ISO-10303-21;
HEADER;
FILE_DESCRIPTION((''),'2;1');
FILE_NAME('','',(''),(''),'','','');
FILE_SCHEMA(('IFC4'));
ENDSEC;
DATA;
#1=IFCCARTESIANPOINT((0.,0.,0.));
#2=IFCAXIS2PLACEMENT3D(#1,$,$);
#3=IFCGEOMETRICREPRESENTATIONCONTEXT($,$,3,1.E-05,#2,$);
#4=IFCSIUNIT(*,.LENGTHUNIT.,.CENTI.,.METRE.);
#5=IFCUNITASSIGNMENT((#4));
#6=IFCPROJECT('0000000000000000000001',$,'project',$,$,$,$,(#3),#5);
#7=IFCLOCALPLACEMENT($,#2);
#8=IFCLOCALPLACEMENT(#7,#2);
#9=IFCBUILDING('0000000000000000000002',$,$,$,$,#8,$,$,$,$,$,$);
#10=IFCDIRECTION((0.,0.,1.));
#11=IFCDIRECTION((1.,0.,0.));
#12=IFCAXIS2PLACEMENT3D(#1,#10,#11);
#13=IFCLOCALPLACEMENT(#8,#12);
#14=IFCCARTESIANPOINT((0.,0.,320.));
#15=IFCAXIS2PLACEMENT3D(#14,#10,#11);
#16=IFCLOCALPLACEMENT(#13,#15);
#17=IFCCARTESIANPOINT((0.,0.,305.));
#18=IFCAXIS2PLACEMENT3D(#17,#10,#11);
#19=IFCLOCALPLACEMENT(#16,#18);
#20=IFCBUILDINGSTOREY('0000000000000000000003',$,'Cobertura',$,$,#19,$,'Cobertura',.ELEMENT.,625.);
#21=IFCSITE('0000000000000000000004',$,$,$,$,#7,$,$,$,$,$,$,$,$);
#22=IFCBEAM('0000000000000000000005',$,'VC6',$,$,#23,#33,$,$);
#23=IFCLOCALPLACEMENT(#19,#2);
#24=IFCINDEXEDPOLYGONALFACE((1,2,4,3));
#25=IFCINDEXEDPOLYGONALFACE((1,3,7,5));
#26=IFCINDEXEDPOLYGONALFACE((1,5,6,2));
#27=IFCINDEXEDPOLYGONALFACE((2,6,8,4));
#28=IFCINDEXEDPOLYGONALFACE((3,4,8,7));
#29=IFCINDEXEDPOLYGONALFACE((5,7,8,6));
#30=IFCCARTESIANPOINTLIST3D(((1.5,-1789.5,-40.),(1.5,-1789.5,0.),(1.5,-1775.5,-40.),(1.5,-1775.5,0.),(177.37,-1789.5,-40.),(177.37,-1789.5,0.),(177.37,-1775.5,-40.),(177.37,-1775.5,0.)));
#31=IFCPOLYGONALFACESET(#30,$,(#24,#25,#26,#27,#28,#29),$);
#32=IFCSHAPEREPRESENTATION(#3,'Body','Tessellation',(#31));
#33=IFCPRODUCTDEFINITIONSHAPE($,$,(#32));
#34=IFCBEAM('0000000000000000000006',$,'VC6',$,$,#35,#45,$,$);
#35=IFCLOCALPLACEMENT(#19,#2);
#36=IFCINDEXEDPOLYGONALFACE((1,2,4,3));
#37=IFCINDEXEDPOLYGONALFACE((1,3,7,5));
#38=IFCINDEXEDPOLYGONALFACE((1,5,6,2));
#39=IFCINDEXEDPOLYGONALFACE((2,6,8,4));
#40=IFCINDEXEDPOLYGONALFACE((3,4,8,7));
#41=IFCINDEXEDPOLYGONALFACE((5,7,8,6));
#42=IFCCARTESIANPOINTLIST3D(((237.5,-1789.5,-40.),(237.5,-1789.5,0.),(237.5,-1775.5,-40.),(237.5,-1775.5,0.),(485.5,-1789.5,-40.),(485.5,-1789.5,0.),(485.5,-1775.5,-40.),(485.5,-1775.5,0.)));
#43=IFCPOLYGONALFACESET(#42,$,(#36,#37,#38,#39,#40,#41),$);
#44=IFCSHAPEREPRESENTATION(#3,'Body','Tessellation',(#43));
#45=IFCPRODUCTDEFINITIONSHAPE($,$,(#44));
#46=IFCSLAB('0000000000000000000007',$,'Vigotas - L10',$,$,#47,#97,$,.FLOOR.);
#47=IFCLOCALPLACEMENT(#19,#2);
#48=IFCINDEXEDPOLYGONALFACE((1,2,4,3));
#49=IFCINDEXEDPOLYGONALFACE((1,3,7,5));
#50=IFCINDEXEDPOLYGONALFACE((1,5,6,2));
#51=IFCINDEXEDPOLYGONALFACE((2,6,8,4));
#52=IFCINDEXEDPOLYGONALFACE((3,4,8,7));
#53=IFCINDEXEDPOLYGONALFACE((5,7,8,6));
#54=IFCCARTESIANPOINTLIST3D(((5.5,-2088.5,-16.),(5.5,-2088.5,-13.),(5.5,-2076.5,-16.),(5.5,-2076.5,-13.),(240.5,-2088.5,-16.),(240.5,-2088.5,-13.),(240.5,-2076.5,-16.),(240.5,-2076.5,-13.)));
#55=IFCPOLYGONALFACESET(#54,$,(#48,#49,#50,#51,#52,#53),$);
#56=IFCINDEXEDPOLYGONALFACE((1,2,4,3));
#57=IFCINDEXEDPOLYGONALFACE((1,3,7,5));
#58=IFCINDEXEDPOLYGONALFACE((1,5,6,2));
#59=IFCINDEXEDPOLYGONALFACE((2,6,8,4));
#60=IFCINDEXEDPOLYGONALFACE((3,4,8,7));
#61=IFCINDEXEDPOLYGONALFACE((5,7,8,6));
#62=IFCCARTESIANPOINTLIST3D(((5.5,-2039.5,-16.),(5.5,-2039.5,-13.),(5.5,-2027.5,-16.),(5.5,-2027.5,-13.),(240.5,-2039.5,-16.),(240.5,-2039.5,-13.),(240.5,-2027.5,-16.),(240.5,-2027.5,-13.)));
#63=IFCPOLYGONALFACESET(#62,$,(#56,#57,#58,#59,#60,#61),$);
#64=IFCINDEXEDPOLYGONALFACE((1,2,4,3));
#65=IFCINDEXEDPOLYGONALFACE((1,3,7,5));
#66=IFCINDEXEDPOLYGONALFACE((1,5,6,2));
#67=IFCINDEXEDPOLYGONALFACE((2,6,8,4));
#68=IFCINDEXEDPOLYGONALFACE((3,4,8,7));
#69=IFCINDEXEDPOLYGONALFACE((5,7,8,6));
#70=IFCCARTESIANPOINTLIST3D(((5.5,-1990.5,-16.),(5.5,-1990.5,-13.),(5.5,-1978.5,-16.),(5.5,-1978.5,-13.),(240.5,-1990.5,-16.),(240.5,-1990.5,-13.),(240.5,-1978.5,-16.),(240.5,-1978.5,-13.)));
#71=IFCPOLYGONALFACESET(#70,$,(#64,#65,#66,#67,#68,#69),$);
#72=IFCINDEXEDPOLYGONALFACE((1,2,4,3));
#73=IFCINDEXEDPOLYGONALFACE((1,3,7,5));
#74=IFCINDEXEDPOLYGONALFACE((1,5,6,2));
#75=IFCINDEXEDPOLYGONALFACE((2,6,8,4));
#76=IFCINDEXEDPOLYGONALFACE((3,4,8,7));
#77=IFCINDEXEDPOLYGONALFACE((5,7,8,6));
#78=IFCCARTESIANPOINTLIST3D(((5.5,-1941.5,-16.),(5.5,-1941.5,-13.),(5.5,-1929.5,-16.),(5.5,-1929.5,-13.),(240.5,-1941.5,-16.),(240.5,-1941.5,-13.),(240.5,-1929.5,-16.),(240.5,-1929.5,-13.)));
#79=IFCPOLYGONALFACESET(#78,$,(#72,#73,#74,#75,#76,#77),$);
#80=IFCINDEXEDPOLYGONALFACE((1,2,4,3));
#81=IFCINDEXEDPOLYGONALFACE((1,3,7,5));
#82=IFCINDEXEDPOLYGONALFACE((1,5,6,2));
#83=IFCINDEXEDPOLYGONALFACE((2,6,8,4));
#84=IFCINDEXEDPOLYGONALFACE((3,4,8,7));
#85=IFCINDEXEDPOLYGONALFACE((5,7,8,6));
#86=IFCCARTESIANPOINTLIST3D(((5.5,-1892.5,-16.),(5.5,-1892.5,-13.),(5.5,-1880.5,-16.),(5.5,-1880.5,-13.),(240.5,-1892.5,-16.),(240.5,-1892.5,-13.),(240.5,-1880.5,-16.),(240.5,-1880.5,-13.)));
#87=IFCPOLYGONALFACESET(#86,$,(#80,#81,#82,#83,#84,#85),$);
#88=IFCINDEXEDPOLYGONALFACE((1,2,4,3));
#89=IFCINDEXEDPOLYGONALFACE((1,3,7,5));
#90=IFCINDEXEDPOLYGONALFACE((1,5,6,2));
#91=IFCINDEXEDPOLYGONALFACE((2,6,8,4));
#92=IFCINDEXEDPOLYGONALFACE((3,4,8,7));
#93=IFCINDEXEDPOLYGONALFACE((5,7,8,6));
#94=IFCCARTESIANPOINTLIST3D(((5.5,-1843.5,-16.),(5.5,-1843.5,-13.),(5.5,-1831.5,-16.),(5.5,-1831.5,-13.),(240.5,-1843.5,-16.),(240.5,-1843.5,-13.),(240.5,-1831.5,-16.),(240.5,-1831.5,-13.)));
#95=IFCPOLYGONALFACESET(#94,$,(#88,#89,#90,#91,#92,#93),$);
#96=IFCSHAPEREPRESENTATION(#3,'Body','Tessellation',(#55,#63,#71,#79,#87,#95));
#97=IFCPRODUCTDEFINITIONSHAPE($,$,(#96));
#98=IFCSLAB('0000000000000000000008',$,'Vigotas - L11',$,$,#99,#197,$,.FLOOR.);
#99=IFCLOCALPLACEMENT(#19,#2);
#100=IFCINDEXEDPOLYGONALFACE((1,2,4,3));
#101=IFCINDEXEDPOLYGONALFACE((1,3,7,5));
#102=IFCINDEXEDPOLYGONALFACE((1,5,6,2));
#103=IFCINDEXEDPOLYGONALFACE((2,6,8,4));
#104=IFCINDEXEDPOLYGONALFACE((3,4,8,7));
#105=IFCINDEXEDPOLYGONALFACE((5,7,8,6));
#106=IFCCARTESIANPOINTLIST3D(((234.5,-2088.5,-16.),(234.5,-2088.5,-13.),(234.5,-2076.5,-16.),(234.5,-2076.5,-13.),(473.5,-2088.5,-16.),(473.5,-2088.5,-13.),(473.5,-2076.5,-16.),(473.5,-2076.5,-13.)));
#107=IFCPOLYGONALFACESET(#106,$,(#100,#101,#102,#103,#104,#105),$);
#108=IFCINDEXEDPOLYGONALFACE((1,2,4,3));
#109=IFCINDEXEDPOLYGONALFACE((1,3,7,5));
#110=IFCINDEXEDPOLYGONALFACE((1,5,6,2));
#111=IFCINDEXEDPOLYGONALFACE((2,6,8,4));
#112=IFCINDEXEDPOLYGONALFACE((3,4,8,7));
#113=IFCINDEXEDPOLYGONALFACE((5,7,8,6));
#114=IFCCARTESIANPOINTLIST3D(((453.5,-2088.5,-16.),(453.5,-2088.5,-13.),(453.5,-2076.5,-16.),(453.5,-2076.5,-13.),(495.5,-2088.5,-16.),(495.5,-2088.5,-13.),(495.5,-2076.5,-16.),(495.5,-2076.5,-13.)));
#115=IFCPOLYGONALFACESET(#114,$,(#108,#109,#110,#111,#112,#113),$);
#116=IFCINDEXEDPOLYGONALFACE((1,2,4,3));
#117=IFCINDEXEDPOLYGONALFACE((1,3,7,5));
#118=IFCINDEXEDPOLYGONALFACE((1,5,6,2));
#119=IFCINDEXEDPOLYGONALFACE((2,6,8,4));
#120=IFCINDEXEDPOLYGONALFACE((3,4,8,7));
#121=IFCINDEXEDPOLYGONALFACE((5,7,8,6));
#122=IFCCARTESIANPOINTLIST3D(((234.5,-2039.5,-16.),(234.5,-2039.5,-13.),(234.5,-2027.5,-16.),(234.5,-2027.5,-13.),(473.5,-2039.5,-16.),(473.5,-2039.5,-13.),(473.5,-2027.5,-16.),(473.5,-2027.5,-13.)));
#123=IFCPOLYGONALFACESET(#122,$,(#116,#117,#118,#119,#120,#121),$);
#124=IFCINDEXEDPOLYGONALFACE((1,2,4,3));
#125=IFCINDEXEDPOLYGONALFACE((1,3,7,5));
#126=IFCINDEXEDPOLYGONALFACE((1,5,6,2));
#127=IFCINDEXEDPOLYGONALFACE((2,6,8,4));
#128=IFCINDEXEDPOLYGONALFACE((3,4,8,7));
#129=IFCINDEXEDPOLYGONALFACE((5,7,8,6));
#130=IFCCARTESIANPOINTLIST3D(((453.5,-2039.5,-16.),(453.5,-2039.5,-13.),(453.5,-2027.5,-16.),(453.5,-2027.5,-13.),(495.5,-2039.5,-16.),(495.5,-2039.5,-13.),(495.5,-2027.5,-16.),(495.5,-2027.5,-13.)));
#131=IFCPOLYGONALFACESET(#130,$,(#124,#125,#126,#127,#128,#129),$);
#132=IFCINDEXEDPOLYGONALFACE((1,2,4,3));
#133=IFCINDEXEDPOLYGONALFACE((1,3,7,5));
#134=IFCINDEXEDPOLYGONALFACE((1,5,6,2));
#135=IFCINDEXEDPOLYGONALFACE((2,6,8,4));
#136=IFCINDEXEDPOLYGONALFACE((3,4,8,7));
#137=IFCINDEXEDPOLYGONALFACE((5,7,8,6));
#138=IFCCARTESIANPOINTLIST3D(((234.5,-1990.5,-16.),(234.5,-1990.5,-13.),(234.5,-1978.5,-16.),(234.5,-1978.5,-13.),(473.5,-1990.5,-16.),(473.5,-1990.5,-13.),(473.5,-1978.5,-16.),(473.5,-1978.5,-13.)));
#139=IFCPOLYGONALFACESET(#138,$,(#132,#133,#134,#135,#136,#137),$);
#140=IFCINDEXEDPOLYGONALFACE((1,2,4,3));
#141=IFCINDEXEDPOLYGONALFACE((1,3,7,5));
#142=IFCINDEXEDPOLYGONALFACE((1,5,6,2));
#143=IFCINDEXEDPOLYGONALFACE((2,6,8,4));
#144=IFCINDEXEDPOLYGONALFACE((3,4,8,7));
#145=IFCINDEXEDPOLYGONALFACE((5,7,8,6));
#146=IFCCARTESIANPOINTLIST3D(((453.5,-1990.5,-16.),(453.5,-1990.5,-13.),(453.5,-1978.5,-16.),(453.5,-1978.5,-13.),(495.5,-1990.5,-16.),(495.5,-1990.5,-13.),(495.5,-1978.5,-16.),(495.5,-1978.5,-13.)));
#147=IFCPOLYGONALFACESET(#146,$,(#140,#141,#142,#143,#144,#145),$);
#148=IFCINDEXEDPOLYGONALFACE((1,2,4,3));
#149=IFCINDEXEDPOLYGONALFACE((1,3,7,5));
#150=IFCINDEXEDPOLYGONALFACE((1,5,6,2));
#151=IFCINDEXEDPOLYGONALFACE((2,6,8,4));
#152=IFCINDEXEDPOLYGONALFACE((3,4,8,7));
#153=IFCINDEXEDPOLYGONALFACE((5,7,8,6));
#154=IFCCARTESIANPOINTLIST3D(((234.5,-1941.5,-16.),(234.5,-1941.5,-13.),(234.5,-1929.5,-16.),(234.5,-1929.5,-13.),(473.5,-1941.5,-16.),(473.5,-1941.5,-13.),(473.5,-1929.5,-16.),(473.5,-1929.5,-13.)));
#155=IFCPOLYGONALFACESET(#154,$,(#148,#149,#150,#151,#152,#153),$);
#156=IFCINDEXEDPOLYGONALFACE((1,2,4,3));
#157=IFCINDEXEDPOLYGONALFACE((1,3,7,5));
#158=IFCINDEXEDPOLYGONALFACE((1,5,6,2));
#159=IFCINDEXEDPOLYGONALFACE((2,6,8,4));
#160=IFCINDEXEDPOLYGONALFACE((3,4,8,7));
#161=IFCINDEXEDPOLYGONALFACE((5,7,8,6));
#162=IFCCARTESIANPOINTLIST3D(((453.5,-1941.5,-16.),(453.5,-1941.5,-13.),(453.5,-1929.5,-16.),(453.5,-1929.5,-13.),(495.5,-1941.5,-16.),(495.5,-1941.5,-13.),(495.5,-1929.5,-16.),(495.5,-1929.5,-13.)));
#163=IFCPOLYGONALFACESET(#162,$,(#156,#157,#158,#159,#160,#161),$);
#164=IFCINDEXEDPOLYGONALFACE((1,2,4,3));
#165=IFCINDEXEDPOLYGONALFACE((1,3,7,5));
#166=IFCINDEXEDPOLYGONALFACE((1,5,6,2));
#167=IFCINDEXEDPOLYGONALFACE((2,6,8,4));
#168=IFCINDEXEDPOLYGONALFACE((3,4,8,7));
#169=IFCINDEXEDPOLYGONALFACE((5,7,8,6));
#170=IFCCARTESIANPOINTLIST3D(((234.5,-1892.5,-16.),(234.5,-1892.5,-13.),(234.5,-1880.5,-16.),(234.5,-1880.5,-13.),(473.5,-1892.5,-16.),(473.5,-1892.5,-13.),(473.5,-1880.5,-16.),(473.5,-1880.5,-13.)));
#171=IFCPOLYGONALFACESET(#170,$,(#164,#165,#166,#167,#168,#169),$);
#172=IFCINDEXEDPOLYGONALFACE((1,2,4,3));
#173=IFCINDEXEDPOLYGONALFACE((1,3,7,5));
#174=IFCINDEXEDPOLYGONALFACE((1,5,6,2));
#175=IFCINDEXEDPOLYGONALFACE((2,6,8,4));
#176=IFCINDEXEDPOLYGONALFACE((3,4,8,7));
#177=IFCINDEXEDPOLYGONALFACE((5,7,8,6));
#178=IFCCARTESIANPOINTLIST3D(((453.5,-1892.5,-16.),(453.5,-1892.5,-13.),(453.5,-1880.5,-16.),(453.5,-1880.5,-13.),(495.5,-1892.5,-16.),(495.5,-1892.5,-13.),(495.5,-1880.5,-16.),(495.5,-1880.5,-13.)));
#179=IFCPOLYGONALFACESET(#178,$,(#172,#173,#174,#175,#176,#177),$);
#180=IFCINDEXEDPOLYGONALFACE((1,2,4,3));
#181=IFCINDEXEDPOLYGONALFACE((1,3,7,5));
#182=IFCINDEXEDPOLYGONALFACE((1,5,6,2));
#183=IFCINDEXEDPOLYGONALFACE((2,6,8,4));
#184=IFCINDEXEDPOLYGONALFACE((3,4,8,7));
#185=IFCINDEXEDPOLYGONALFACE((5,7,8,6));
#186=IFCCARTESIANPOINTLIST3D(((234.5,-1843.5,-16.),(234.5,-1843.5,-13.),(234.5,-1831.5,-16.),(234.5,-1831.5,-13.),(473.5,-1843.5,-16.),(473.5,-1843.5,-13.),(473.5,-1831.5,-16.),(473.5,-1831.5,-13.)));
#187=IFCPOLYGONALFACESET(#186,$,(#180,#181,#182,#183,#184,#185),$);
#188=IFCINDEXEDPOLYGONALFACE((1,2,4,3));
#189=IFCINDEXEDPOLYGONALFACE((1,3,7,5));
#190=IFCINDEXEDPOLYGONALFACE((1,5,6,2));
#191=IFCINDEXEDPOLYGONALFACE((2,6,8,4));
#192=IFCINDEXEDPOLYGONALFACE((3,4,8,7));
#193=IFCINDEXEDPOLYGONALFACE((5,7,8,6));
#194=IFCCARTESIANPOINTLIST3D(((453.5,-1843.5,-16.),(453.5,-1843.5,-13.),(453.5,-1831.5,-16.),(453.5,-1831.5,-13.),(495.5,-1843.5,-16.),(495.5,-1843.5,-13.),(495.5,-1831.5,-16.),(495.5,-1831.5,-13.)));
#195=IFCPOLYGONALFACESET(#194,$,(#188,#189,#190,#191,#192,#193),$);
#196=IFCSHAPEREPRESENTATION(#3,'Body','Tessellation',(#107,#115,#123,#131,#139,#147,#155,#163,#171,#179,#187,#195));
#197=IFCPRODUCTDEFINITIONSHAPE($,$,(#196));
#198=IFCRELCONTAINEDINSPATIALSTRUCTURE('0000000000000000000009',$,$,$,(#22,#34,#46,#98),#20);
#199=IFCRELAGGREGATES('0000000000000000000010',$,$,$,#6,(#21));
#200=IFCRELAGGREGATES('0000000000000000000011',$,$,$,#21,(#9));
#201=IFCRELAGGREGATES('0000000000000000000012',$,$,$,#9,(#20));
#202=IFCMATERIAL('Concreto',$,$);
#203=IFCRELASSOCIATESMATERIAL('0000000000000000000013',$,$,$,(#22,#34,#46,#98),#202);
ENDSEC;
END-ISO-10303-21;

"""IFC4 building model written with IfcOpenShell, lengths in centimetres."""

from ifc_helpers import new_model, si_unit, frame, origin, origin_with_axes, place, context, project, spatial, polyline, outline, extrude, material, element, save


model = new_model("IFC4")

# Units and contexts
context_of_model = context(None, 3, precision=1e-05, world=origin())
ifc_project = project(units=[si_unit("LENGTHUNIT", "METRE", prefix="CENTI")], contexts=[context_of_model])

# Site, building, storey
site_placement = place(None, origin())
site = spatial("IfcSite", under=ifc_project, at=site_placement)
building_placement = place(site_placement, origin())
building = spatial("IfcBuilding", under=site, at=building_placement)
placement_1 = place(building_placement, origin_with_axes())
placement_2 = place(placement_1, frame((0.0, 0.0, 320.0), z_axis=(0.0, 0.0, 1.0), x_axis=(1.0, 0.0, 0.0)))
storey_placement = place(placement_2, frame((0.0, 0.0, 305.0), z_axis=(0.0, 0.0, 1.0), x_axis=(1.0, 0.0, 0.0)))
storey = spatial("IfcBuildingStorey", under=building, at=storey_placement, Name="Cobertura", LongName="Cobertura", CompositionType="ELEMENT", Elevation=625.0)

# Shared definitions
ifc_material = material(Name="Concreto")

# Beams
beam_1_placement = place(storey_placement, frame((89.44, -1782.5, 0.0), z_axis=(0.0, 0.0, 1.0), x_axis=(1.0, 0.0, 0.0)))
element("IfcBeam", 1, at=beam_1_placement, inside=storey, material=ifc_material, Name="VC6", context=context_of_model, shape_type="SolidModel", body=[
    extrude(outline(polyline([(-7.0, -20.0), (7.0, -20.0), (7.0, 20.0), (-7.0, 20.0), (-7.0, -20.0)])), frame((-87.94, 0.0, -20.0), z_axis=(1.0, 0.0, 0.0), x_axis=(0.0, -1.0, 0.0)), (0.0, 0.0, 1.0), 175.87),
])
beam_2_placement = place(storey_placement, frame((361.5, -1782.5, 0.0), z_axis=(0.0, 0.0, 1.0), x_axis=(1.0, 0.0, 0.0)))
element("IfcBeam", 2, at=beam_2_placement, inside=storey, material=ifc_material, Name="VC6", context=context_of_model, shape_type="SolidModel", body=[
    extrude(outline(polyline([(-7.0, -20.0), (7.0, -20.0), (7.0, 20.0), (-7.0, 20.0), (-7.0, -20.0)])), frame((-124.0, 0.0, -20.0), z_axis=(1.0, 0.0, 0.0), x_axis=(0.0, -1.0, 0.0)), (0.0, 0.0, 1.0), 248.0),
])

# Slabs
slab_1_placement = place(storey_placement, frame((123.0, -1960.0, -13.0), z_axis=(0.0, 0.0, 1.0), x_axis=(1.0, 0.0, 0.0)))
element("IfcSlab", 3, at=slab_1_placement, inside=storey, material=ifc_material, Name="Vigotas - L10", PredefinedType="FLOOR", context=context_of_model, shape_type="SolidModel", body=[
    extrude(outline(polyline([(6.0, 1.5), (-6.0, 1.5), (-6.0, -1.5), (6.0, -1.5), (6.0, 1.5), (6.0, 1.5)])), frame((-117.5, -122.5, -1.5), z_axis=(1.0, 0.0, 0.0), x_axis=(0.0, -1.0, 0.0)), (0.0, 0.0, 1.0), 235.0),
    extrude(outline(polyline([(6.0, 1.5), (-6.0, 1.5), (-6.0, -1.5), (6.0, -1.5), (6.0, 1.5), (6.0, 1.5)])), frame((-117.5, -73.5, -1.5), z_axis=(1.0, 0.0, 0.0), x_axis=(0.0, -1.0, 0.0)), (0.0, 0.0, 1.0), 235.0),
    extrude(outline(polyline([(6.0, 1.5), (-6.0, 1.5), (-6.0, -1.5), (6.0, -1.5), (6.0, 1.5), (6.0, 1.5)])), frame((-117.5, -24.5, -1.5), z_axis=(1.0, 0.0, 0.0), x_axis=(0.0, -1.0, 0.0)), (0.0, 0.0, 1.0), 235.0),
    extrude(outline(polyline([(6.0, 1.5), (-6.0, 1.5), (-6.0, -1.5), (6.0, -1.5), (6.0, 1.5), (6.0, 1.5)])), frame((-117.5, 24.5, -1.5), z_axis=(1.0, 0.0, 0.0), x_axis=(0.0, -1.0, 0.0)), (0.0, 0.0, 1.0), 235.0),
    extrude(outline(polyline([(6.0, 1.5), (-6.0, 1.5), (-6.0, -1.5), (6.0, -1.5), (6.0, 1.5), (6.0, 1.5)])), frame((-117.5, 73.5, -1.5), z_axis=(1.0, 0.0, 0.0), x_axis=(0.0, -1.0, 0.0)), (0.0, 0.0, 1.0), 235.0),
    extrude(outline(polyline([(6.0, 1.5), (-6.0, 1.5), (-6.0, -1.5), (6.0, -1.5), (6.0, 1.5), (6.0, 1.5)])), frame((-117.5, 122.5, -1.5), z_axis=(1.0, 0.0, 0.0), x_axis=(0.0, -1.0, 0.0)), (0.0, 0.0, 1.0), 235.0),
])
slab_2_placement = place(storey_placement, frame((365.0, -1960.0, -13.0), z_axis=(0.0, 0.0, 1.0), x_axis=(1.0, 0.0, 0.0)))
element("IfcSlab", 4, at=slab_2_placement, inside=storey, material=ifc_material, Name="Vigotas - L11", PredefinedType="FLOOR", context=context_of_model, shape_type="SolidModel", body=[
    extrude(outline(polyline([(6.0, 1.5), (-6.0, 1.5), (-6.0, -1.5), (6.0, -1.5), (6.0, 1.5), (6.0, 1.5)])), frame((-130.5, -122.5, -1.5), z_axis=(1.0, 0.0, 0.0), x_axis=(0.0, -1.0, 0.0)), (0.0, 0.0, 1.0), 239.0),
    extrude(outline(polyline([(6.0, 1.5), (-6.0, 1.5), (-6.0, -1.5), (6.0, -1.5), (6.0, 1.5), (6.0, 1.5)])), frame((88.5, -122.5, -1.5), z_axis=(1.0, 0.0, 0.0), x_axis=(0.0, -1.0, 0.0)), (0.0, 0.0, 1.0), 42.0),
    extrude(outline(polyline([(6.0, 1.5), (-6.0, 1.5), (-6.0, -1.5), (6.0, -1.5), (6.0, 1.5), (6.0, 1.5)])), frame((-130.5, -73.5, -1.5), z_axis=(1.0, 0.0, 0.0), x_axis=(0.0, -1.0, 0.0)), (0.0, 0.0, 1.0), 239.0),
    extrude(outline(polyline([(6.0, 1.5), (-6.0, 1.5), (-6.0, -1.5), (6.0, -1.5), (6.0, 1.5), (6.0, 1.5)])), frame((88.5, -73.5, -1.5), z_axis=(1.0, 0.0, 0.0), x_axis=(0.0, -1.0, 0.0)), (0.0, 0.0, 1.0), 42.0),
    extrude(outline(polyline([(6.0, 1.5), (-6.0, 1.5), (-6.0, -1.5), (6.0, -1.5), (6.0, 1.5), (6.0, 1.5)])), frame((-130.5, -24.5, -1.5), z_axis=(1.0, 0.0, 0.0), x_axis=(0.0, -1.0, 0.0)), (0.0, 0.0, 1.0), 239.0),
    extrude(outline(polyline([(6.0, 1.5), (-6.0, 1.5), (-6.0, -1.5), (6.0, -1.5), (6.0, 1.5), (6.0, 1.5)])), frame((88.5, -24.5, -1.5), z_axis=(1.0, 0.0, 0.0), x_axis=(0.0, -1.0, 0.0)), (0.0, 0.0, 1.0), 42.0),
    extrude(outline(polyline([(6.0, 1.5), (-6.0, 1.5), (-6.0, -1.5), (6.0, -1.5), (6.0, 1.5), (6.0, 1.5)])), frame((-130.5, 24.5, -1.5), z_axis=(1.0, 0.0, 0.0), x_axis=(0.0, -1.0, 0.0)), (0.0, 0.0, 1.0), 239.0),
    extrude(outline(polyline([(6.0, 1.5), (-6.0, 1.5), (-6.0, -1.5), (6.0, -1.5), (6.0, 1.5), (6.0, 1.5)])), frame((88.5, 24.5, -1.5), z_axis=(1.0, 0.0, 0.0), x_axis=(0.0, -1.0, 0.0)), (0.0, 0.0, 1.0), 42.0),
    extrude(outline(polyline([(6.0, 1.5), (-6.0, 1.5), (-6.0, -1.5), (6.0, -1.5), (6.0, 1.5), (6.0, 1.5)])), frame((-130.5, 73.5, -1.5), z_axis=(1.0, 0.0, 0.0), x_axis=(0.0, -1.0, 0.0)), (0.0, 0.0, 1.0), 239.0),
    extrude(outline(polyline([(6.0, 1.5), (-6.0, 1.5), (-6.0, -1.5), (6.0, -1.5), (6.0, 1.5), (6.0, 1.5)])), frame((88.5, 73.5, -1.5), z_axis=(1.0, 0.0, 0.0), x_axis=(0.0, -1.0, 0.0)), (0.0, 0.0, 1.0), 42.0),
    extrude(outline(polyline([(6.0, 1.5), (-6.0, 1.5), (-6.0, -1.5), (6.0, -1.5), (6.0, 1.5), (6.0, 1.5)])), frame((-130.5, 122.5, -1.5), z_axis=(1.0, 0.0, 0.0), x_axis=(0.0, -1.0, 0.0)), (0.0, 0.0, 1.0), 239.0),
    extrude(outline(polyline([(6.0, 1.5), (-6.0, 1.5), (-6.0, -1.5), (6.0, -1.5), (6.0, 1.5), (6.0, 1.5)])), frame((88.5, 122.5, -1.5), z_axis=(1.0, 0.0, 0.0), x_axis=(0.0, -1.0, 0.0)), (0.0, 0.0, 1.0), 42.0),
])

save(model, "model.ifc")
